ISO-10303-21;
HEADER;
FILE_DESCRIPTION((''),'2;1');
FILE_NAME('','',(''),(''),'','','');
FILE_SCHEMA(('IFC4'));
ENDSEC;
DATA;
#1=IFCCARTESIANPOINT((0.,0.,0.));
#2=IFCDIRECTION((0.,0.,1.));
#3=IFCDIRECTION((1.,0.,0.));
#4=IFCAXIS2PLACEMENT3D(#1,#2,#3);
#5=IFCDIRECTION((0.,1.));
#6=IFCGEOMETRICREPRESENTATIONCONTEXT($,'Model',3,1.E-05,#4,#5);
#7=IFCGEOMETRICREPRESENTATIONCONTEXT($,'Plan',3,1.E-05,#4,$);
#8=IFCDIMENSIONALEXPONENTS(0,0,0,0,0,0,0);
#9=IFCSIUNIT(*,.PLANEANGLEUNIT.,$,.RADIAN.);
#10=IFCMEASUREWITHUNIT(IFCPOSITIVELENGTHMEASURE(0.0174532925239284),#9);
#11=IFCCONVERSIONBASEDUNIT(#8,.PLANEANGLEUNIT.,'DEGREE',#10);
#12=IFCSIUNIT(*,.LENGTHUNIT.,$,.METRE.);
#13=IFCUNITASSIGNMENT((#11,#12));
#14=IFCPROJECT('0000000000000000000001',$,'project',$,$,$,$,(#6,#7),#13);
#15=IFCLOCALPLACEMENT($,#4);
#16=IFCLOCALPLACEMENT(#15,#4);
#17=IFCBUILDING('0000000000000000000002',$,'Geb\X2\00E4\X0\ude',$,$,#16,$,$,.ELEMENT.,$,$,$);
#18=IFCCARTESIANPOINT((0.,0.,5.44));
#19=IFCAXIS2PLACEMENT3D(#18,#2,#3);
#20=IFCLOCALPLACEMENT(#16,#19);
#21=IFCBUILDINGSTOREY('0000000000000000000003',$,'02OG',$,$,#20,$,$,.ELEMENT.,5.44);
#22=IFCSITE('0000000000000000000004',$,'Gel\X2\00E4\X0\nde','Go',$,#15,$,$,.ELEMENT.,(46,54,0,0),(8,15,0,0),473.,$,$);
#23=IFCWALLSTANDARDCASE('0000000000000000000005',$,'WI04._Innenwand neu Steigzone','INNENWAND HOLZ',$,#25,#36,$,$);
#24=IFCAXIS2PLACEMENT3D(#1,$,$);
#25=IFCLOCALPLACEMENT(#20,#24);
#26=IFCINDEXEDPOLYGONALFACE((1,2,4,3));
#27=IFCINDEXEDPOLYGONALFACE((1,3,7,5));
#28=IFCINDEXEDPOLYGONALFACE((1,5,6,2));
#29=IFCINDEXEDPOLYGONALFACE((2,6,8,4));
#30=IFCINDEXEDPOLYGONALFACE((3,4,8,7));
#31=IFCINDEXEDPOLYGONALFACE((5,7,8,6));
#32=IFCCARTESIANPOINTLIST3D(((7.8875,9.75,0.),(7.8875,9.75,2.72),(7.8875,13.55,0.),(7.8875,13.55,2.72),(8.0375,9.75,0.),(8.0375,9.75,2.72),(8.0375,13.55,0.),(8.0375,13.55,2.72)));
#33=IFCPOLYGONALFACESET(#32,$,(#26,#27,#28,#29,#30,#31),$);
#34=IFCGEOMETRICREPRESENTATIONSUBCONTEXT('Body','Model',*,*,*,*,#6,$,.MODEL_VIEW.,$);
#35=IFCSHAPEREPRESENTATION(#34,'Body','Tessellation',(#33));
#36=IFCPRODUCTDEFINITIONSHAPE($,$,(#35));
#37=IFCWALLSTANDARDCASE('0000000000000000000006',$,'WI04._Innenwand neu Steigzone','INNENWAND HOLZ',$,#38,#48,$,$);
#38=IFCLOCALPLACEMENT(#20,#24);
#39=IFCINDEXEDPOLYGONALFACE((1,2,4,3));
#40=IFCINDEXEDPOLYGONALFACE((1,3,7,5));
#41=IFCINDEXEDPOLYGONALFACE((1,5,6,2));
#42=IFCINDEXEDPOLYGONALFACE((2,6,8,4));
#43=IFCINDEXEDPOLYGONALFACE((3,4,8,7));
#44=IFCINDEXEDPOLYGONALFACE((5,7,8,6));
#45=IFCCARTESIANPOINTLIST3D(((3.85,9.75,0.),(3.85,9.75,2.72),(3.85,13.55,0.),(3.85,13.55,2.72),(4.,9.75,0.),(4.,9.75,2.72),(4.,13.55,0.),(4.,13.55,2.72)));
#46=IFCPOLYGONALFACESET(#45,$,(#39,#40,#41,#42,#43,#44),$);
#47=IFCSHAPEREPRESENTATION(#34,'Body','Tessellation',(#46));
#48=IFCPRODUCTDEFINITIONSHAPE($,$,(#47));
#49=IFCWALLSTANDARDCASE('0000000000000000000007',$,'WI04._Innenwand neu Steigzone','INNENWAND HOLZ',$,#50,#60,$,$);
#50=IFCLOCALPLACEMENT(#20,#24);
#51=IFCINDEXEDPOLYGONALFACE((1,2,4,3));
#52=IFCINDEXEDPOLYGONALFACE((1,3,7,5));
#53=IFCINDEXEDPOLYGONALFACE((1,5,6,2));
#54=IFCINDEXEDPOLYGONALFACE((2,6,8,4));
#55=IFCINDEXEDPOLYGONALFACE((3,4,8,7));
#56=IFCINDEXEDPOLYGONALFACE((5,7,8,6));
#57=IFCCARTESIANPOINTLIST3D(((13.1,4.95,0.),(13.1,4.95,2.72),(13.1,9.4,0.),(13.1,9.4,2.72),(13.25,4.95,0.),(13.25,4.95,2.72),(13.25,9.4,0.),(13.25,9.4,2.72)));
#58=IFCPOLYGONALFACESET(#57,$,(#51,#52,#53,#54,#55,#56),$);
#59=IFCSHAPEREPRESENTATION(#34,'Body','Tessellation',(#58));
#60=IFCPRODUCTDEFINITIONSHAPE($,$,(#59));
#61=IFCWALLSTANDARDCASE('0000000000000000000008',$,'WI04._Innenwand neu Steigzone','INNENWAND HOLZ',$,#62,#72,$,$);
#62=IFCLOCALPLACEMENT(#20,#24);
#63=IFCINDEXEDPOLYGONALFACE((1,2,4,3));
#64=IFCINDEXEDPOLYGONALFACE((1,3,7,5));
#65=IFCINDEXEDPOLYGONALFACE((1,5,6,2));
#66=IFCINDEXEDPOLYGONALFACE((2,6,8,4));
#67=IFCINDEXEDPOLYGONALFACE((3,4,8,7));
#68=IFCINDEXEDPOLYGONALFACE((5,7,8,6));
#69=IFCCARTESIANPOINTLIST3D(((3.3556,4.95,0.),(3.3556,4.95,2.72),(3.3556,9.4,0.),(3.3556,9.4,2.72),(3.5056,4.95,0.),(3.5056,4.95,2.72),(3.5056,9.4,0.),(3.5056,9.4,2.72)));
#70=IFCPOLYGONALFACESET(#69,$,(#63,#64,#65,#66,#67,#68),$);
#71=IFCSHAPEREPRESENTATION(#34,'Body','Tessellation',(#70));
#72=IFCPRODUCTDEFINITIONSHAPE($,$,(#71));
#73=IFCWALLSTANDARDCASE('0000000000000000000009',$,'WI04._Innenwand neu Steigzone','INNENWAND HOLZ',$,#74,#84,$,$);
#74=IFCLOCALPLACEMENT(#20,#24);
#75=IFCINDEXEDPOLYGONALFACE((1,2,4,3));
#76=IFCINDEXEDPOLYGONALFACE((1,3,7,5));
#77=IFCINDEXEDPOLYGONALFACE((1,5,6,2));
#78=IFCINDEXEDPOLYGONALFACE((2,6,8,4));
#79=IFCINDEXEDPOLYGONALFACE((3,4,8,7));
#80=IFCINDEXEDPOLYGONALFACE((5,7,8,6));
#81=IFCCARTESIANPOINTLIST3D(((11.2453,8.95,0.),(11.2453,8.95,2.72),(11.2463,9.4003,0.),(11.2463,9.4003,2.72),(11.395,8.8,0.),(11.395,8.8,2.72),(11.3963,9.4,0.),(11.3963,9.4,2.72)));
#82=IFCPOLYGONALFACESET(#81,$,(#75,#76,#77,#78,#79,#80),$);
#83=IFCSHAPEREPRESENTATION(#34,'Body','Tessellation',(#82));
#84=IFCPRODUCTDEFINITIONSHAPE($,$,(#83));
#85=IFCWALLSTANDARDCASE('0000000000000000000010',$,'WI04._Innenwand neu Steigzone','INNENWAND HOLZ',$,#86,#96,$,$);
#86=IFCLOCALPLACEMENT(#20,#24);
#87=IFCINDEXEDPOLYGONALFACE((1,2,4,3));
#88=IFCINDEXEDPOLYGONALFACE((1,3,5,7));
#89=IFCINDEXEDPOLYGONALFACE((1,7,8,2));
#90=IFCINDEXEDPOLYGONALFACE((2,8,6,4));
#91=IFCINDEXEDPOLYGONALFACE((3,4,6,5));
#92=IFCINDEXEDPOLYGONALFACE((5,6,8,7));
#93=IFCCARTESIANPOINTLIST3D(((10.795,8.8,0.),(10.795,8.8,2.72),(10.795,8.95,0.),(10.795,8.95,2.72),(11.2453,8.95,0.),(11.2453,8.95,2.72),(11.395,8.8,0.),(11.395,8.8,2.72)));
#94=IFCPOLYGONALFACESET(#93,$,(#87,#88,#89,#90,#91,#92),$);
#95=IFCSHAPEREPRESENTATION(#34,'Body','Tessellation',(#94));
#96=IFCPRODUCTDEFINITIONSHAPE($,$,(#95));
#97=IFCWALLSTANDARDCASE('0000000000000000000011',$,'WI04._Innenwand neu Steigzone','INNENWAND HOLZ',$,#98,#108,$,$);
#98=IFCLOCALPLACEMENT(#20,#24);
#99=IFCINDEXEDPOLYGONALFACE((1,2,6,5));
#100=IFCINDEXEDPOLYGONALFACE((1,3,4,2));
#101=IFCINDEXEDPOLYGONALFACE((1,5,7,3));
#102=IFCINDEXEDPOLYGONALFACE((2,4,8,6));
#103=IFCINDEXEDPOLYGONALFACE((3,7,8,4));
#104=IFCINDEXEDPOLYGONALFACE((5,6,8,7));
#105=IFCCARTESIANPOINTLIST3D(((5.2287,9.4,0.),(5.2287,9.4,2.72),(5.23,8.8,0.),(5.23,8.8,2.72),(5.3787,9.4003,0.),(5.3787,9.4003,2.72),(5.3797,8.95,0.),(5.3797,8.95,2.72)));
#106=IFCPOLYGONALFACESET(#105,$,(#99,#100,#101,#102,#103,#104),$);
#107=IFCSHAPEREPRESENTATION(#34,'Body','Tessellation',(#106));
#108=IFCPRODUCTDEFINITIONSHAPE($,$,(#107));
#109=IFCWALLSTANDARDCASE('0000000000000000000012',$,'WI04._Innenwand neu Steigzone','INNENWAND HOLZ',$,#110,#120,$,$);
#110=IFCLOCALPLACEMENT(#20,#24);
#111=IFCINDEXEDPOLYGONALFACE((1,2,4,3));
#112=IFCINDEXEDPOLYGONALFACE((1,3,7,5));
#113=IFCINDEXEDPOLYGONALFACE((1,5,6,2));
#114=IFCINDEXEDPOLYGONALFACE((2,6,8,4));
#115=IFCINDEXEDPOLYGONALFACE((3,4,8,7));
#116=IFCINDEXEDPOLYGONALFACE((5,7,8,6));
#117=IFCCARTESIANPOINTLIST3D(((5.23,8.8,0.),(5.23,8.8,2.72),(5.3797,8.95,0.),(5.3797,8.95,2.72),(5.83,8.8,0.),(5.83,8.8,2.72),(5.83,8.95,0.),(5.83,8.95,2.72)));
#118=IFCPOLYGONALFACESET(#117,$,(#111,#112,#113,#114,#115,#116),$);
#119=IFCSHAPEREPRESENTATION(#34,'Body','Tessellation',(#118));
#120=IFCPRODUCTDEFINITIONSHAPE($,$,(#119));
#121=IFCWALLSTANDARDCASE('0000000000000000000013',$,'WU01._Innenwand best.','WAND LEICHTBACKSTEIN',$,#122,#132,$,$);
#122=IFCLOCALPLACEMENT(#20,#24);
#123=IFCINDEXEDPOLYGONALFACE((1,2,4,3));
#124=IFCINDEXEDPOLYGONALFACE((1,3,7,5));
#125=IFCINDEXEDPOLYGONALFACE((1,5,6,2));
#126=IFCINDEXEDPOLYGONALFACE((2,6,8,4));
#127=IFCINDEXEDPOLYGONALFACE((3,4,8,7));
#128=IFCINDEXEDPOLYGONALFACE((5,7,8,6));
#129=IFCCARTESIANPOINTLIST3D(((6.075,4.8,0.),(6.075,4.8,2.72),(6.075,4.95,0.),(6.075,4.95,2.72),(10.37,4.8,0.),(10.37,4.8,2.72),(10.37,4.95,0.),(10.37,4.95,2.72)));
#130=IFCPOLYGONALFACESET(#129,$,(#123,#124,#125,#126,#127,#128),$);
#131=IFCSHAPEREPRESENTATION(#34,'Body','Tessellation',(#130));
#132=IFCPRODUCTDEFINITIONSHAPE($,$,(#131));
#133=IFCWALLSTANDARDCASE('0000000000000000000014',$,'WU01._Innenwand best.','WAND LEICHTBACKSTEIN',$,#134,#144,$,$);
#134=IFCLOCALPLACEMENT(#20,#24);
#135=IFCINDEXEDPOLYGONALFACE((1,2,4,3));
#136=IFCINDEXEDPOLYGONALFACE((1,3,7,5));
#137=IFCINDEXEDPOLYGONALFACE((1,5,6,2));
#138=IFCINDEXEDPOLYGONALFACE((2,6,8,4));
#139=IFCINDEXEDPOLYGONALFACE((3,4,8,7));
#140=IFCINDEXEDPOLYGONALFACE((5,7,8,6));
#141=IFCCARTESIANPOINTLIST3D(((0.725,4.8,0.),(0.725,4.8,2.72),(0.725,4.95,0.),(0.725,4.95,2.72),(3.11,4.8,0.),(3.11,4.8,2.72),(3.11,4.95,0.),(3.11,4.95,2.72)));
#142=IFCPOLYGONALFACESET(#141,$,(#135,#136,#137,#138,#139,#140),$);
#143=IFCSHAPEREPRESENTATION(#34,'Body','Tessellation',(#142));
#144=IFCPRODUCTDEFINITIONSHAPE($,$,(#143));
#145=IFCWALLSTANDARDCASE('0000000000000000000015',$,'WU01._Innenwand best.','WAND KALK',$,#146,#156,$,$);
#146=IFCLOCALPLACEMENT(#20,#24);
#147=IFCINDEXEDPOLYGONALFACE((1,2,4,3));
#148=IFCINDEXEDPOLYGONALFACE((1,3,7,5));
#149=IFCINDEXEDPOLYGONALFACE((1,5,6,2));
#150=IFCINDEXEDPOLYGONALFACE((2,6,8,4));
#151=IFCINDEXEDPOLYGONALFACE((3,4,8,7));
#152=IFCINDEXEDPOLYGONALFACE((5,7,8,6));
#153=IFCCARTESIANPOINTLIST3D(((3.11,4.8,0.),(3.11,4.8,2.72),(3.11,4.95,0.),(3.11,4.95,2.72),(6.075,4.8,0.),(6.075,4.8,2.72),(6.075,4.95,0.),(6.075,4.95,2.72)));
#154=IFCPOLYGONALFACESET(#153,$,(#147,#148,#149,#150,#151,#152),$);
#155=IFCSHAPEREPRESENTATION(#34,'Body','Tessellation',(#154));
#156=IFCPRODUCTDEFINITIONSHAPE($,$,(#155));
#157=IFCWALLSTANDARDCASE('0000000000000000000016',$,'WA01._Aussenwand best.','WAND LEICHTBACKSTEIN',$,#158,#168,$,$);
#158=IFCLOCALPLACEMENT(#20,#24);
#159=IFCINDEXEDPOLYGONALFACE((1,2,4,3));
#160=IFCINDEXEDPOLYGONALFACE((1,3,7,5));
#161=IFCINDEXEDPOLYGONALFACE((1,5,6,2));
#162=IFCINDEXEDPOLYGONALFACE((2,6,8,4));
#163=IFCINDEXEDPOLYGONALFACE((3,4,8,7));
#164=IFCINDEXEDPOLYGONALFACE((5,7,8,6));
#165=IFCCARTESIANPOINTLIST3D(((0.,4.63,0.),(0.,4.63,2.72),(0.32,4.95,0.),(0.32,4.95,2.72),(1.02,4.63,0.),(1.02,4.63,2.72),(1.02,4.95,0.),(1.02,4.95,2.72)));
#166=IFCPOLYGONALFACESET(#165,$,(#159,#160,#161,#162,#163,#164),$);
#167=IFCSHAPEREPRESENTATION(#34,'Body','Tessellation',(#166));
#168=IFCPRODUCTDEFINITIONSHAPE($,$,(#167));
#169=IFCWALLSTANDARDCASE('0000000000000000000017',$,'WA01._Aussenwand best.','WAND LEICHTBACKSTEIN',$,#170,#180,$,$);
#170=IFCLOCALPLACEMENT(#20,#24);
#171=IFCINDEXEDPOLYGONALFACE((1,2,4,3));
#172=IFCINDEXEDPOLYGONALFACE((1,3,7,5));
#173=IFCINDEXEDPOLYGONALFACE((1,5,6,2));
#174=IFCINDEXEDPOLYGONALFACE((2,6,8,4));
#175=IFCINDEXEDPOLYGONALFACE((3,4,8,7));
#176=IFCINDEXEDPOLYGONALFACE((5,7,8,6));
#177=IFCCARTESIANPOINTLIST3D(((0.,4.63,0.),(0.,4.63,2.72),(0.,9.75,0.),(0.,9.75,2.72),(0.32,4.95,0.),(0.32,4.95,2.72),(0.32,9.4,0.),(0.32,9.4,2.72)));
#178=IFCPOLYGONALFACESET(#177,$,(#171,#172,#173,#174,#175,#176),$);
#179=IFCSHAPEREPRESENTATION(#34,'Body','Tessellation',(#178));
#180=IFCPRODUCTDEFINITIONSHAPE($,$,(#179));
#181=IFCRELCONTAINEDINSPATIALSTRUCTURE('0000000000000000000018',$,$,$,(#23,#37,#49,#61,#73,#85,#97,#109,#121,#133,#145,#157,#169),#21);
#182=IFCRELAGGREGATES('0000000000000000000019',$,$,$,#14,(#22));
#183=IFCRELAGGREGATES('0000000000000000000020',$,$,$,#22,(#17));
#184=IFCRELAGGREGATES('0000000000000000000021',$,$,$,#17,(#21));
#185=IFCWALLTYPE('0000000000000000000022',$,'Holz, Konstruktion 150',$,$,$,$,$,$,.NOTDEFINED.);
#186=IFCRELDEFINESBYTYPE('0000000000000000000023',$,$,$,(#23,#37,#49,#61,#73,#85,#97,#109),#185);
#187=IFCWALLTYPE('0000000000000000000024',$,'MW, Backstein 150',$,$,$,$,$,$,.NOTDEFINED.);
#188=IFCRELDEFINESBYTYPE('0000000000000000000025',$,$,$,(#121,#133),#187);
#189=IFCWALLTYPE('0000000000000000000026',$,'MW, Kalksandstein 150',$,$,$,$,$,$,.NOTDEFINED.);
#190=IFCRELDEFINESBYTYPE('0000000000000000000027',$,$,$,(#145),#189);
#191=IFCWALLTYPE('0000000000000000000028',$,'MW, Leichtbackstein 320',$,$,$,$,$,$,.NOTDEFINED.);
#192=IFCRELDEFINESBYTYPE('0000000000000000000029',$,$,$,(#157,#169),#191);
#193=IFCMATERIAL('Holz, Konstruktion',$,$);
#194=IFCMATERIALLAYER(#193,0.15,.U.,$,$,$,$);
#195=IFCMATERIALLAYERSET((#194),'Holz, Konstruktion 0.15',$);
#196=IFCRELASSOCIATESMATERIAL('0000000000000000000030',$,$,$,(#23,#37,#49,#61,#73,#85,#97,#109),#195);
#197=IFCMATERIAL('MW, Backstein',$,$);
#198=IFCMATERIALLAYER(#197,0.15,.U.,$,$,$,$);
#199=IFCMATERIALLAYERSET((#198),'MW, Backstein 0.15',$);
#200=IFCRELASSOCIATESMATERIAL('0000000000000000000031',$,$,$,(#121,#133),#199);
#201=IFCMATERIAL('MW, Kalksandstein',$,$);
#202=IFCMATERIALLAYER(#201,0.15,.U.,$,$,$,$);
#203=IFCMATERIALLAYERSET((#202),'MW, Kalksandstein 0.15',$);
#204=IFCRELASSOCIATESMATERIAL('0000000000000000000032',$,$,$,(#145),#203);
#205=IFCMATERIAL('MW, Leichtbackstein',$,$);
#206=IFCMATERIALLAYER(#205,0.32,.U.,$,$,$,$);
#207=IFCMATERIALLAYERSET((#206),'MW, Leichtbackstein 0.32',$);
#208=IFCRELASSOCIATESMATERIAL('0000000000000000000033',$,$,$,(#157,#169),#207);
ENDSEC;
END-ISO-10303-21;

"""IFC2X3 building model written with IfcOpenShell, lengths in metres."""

from ifc_helpers import new_model, entity, si_unit, converted_unit, direction, frame, origin_with_axes, place, context, subcontext, project, spatial, polyline, outline, extrude, material, layer, layer_set, layer_usage, type_object, element, save


model = new_model("IFC2X3")

# Units and contexts
model_context = context("Model", 3, precision=1e-05, world=origin_with_axes(), true_north=direction((0.0, 1.0)))
plan_context = context("Plan", 3, precision=1e-05, world=origin_with_axes())
body_context = subcontext(model_context, "Body", "Model", "MODEL_VIEW")
ifc_project = project(units=[converted_unit("PLANEANGLEUNIT", "DEGREE", entity("IfcPositiveLengthMeasure", 0.0174532925239284), si_unit("PLANEANGLEUNIT", "RADIAN"), dimensions=[0, 0, 0, 0, 0, 0, 0]), si_unit("LENGTHUNIT", "METRE")], contexts=[model_context, plan_context])

# Site, building, storey
site_placement = place(None, origin_with_axes())
site = spatial("IfcSite", under=ifc_project, at=site_placement, Name="Gelände", Description="Go", CompositionType="ELEMENT", RefLatitude=(46, 54, 0, 0), RefLongitude=(8, 15, 0, 0), RefElevation=473.0)
building_placement = place(site_placement, origin_with_axes())
building = spatial("IfcBuilding", under=site, at=building_placement, Name="Gebäude", CompositionType="ELEMENT")
storey_placement = place(building_placement, frame((0.0, 0.0, 5.44), z_axis=(0.0, 0.0, 1.0), x_axis=(1.0, 0.0, 0.0)))
storey = spatial("IfcBuildingStorey", under=building, at=storey_placement, Name="02OG", CompositionType="ELEMENT", Elevation=5.44)

# Shared definitions
ifc_material_1 = material(Name="Holz, Konstruktion")

# Walls
ifc_layer_1 = layer(ifc_material_1, 0.15, ventilated="UNKNOWN")
ifc_layer_set_1 = layer_set([ifc_layer_1], Name="Holz, Konstruktion 0.15")
wall_type_1 = type_object("IfcWallType", Name="Holz, Konstruktion 150", PredefinedType="NOTDEFINED")
ifc_layer_usage_1 = layer_usage(ifc_layer_set_1, "AXIS2", "POSITIVE", 0.0)
wall_1_placement = place(storey_placement, frame((7.8875, 13.55, 0.0), z_axis=(0.0, 0.0, 1.0), x_axis=(0.0, -1.0, 0.0)))
element("IfcWallStandardCase", 1, at=wall_1_placement, inside=storey, type_object=wall_type_1, material=ifc_layer_usage_1, Name="WI04._Innenwand neu Steigzone", Description="INNENWAND HOLZ", context=body_context, shape_type="SweptSolid", body=[
    extrude(outline(polyline([(0.0, 0.0), (3.8, 0.0), (3.8, 0.15), (0.0, 0.15), (0.0, 0.0)])), origin_with_axes(), (0.0, 0.0, 1.0), 2.72),
])
ifc_layer_usage_2 = layer_usage(ifc_layer_set_1, "AXIS2", "NEGATIVE", 0.0)
wall_2_placement = place(storey_placement, frame((4.0, 13.55, 0.0), z_axis=(0.0, 0.0, 1.0), x_axis=(0.0, -1.0, 0.0)))
element("IfcWallStandardCase", 2, at=wall_2_placement, inside=storey, type_object=wall_type_1, material=ifc_layer_usage_2, Name="WI04._Innenwand neu Steigzone", Description="INNENWAND HOLZ", context=body_context, shape_type="SweptSolid", body=[
    extrude(outline(polyline([(0.0, -0.15), (3.8, -0.15), (3.8, 0.0), (0.0, 0.0), (0.0, -0.15)])), origin_with_axes(), (0.0, 0.0, 1.0), 2.72),
])
ifc_layer_usage_3 = layer_usage(ifc_layer_set_1, "AXIS2", "POSITIVE", 0.0)
wall_3_placement = place(storey_placement, frame((13.1, 9.4, 0.0), z_axis=(0.0, 0.0, 1.0), x_axis=(0.0, -1.0, 0.0)))
element("IfcWallStandardCase", 3, at=wall_3_placement, inside=storey, type_object=wall_type_1, material=ifc_layer_usage_3, Name="WI04._Innenwand neu Steigzone", Description="INNENWAND HOLZ", context=body_context, shape_type="SweptSolid", body=[
    extrude(outline(polyline([(0.0, 0.0), (4.45, 0.0), (4.45, 0.15), (0.0, 0.15), (0.0, 0.0)])), origin_with_axes(), (0.0, 0.0, 1.0), 2.72),
])
ifc_layer_usage_4 = layer_usage(ifc_layer_set_1, "AXIS2", "NEGATIVE", 0.0)
wall_4_placement = place(storey_placement, frame((3.5056, 9.4, 0.0), z_axis=(0.0, 0.0, 1.0), x_axis=(0.0, -1.0, 0.0)))
element("IfcWallStandardCase", 4, at=wall_4_placement, inside=storey, type_object=wall_type_1, material=ifc_layer_usage_4, Name="WI04._Innenwand neu Steigzone", Description="INNENWAND HOLZ", context=body_context, shape_type="SweptSolid", body=[
    extrude(outline(polyline([(0.0, -0.15), (4.45, -0.15), (4.45, 0.0), (0.0, 0.0), (0.0, -0.15)])), origin_with_axes(), (0.0, 0.0, 1.0), 2.72),
])
ifc_layer_usage_5 = layer_usage(ifc_layer_set_1, "AXIS2", "NEGATIVE", 0.0)
wall_5_placement = place(storey_placement, frame((11.3963, 9.4, 0.0), z_axis=(0.0, 0.0, 1.0), x_axis=(-0.002118, -0.999998, 0.0)))
element("IfcWallStandardCase", 5, at=wall_5_placement, inside=storey, type_object=wall_type_1, material=ifc_layer_usage_5, Name="WI04._Innenwand neu Steigzone", Description="INNENWAND HOLZ", context=body_context, shape_type="SweptSolid", body=[
    extrude(outline(polyline([(0.0, -0.15), (0.4503, -0.15), (0.6, 0.0), (0.0, 0.0), (0.0, -0.15)])), origin_with_axes(), (0.0, 0.0, 1.0), 2.72),
])
ifc_layer_usage_6 = layer_usage(ifc_layer_set_1, "AXIS2", "NEGATIVE", 0.0)
wall_6_placement = place(storey_placement, frame((11.395, 8.8, 0.0), z_axis=(0.0, 0.0, 1.0), x_axis=(-1.0, 0.0, 0.0)))
element("IfcWallStandardCase", 6, at=wall_6_placement, inside=storey, type_object=wall_type_1, material=ifc_layer_usage_6, Name="WI04._Innenwand neu Steigzone", Description="INNENWAND HOLZ", context=body_context, shape_type="SweptSolid", body=[
    extrude(outline(polyline([(0.1497, -0.15), (0.6, -0.15), (0.6, 0.0), (0.0, 0.0), (0.1497, -0.15)])), origin_with_axes(), (0.0, 0.0, 1.0), 2.72),
])
ifc_layer_usage_7 = layer_usage(ifc_layer_set_1, "AXIS2", "POSITIVE", 0.0)
wall_7_placement = place(storey_placement, frame((5.2287, 9.4, 0.0), z_axis=(0.0, 0.0, 1.0), x_axis=(0.002118, -0.999998, 0.0)))
element("IfcWallStandardCase", 7, at=wall_7_placement, inside=storey, type_object=wall_type_1, material=ifc_layer_usage_7, Name="WI04._Innenwand neu Steigzone", Description="INNENWAND HOLZ", context=body_context, shape_type="SweptSolid", body=[
    extrude(outline(polyline([(0.0, 0.0), (0.6, 0.0), (0.4503, 0.15), (0.0, 0.15), (0.0, 0.0)])), origin_with_axes(), (0.0, 0.0, 1.0), 2.72),
])
ifc_layer_usage_8 = layer_usage(ifc_layer_set_1, "AXIS2", "POSITIVE", 0.0)
wall_8_placement = place(storey_placement, frame((5.23, 8.8, 0.0), z_axis=(0.0, 0.0, 1.0), x_axis=(1.0, 0.0, 0.0)))
element("IfcWallStandardCase", 8, at=wall_8_placement, inside=storey, type_object=wall_type_1, material=ifc_layer_usage_8, Name="WI04._Innenwand neu Steigzone", Description="INNENWAND HOLZ", context=body_context, shape_type="SweptSolid", body=[
    extrude(outline(polyline([(0.0, 0.0), (0.6, 0.0), (0.6, 0.15), (0.1497, 0.15), (0.0, 0.0)])), origin_with_axes(), (0.0, 0.0, 1.0), 2.72),
])
ifc_material_2 = material(Name="MW, Backstein")
ifc_layer_2 = layer(ifc_material_2, 0.15, ventilated="UNKNOWN")
ifc_layer_set_2 = layer_set([ifc_layer_2], Name="MW, Backstein 0.15")
ifc_layer_usage_9 = layer_usage(ifc_layer_set_2, "AXIS2", "POSITIVE", -0.15)
wall_type_2 = type_object("IfcWallType", Name="MW, Backstein 150", PredefinedType="NOTDEFINED")
wall_9_placement = place(storey_placement, frame((6.075, 4.95, 0.0), z_axis=(0.0, 0.0, 1.0), x_axis=(1.0, 0.0, 0.0)))
element("IfcWallStandardCase", 9, at=wall_9_placement, inside=storey, type_object=wall_type_2, material=ifc_layer_usage_9, Name="WU01._Innenwand best.", Description="WAND LEICHTBACKSTEIN", context=body_context, shape_type="SweptSolid", body=[
    extrude(outline(polyline([(0.0, -0.15), (4.295, -0.15), (4.295, 0.0), (0.0, 0.0), (0.0, -0.15)])), origin_with_axes(), (0.0, 0.0, 1.0), 2.72),
])
ifc_layer_usage_10 = layer_usage(ifc_layer_set_2, "AXIS2", "POSITIVE", -0.15)
wall_10_placement = place(storey_placement, frame((0.725, 4.95, 0.0), z_axis=(0.0, 0.0, 1.0), x_axis=(1.0, 0.0, 0.0)))
element("IfcWallStandardCase", 10, at=wall_10_placement, inside=storey, type_object=wall_type_2, material=ifc_layer_usage_10, Name="WU01._Innenwand best.", Description="WAND LEICHTBACKSTEIN", context=body_context, shape_type="SweptSolid", body=[
    extrude(outline(polyline([(0.0, -0.15), (2.385, -0.15), (2.385, 0.0), (0.0, 0.0), (0.0, -0.15)])), origin_with_axes(), (0.0, 0.0, 1.0), 2.72),
])
ifc_material_3 = material(Name="MW, Kalksandstein")
ifc_layer_3 = layer(ifc_material_3, 0.15, ventilated="UNKNOWN")
ifc_layer_set_3 = layer_set([ifc_layer_3], Name="MW, Kalksandstein 0.15")
ifc_layer_usage_11 = layer_usage(ifc_layer_set_3, "AXIS2", "POSITIVE", -0.15)
wall_type_3 = type_object("IfcWallType", Name="MW, Kalksandstein 150", PredefinedType="NOTDEFINED")
wall_11_placement = place(storey_placement, frame((3.11, 4.95, 0.0), z_axis=(0.0, 0.0, 1.0), x_axis=(1.0, 0.0, 0.0)))
element("IfcWallStandardCase", 11, at=wall_11_placement, inside=storey, type_object=wall_type_3, material=ifc_layer_usage_11, Name="WU01._Innenwand best.", Description="WAND KALK", context=body_context, shape_type="SweptSolid", body=[
    extrude(outline(polyline([(0.0, -0.15), (2.965, -0.15), (2.965, 0.0), (0.0, 0.0), (0.0, -0.15)])), origin_with_axes(), (0.0, 0.0, 1.0), 2.72),
])
ifc_material_4 = material(Name="MW, Leichtbackstein")
ifc_layer_4 = layer(ifc_material_4, 0.32, ventilated="UNKNOWN")
ifc_layer_set_4 = layer_set([ifc_layer_4], Name="MW, Leichtbackstein 0.32")
wall_type_4 = type_object("IfcWallType", Name="MW, Leichtbackstein 320", PredefinedType="NOTDEFINED")
ifc_layer_usage_12 = layer_usage(ifc_layer_set_4, "AXIS2", "POSITIVE", -0.32)
wall_12_placement = place(storey_placement, frame((0.32, 4.95, 0.0), z_axis=(0.0, 0.0, 1.0), x_axis=(1.0, 0.0, 0.0)))
element("IfcWallStandardCase", 12, at=wall_12_placement, inside=storey, type_object=wall_type_4, material=ifc_layer_usage_12, Name="WA01._Aussenwand best.", Description="WAND LEICHTBACKSTEIN", context=body_context, shape_type="SweptSolid", body=[
    extrude(outline(polyline([(-0.32, -0.32), (0.7, -0.32), (0.7, 0.0), (0.0, 0.0), (-0.32, -0.32)])), origin_with_axes(), (0.0, 0.0, 1.0), 2.72),
])
ifc_layer_usage_13 = layer_usage(ifc_layer_set_4, "AXIS2", "POSITIVE", -0.32)
wall_13_placement = place(storey_placement, frame((0.32, 9.4, 0.0), z_axis=(0.0, 0.0, 1.0), x_axis=(0.0, -1.0, 0.0)))
element("IfcWallStandardCase", 13, at=wall_13_placement, inside=storey, type_object=wall_type_4, material=ifc_layer_usage_13, Name="WA01._Aussenwand best.", Description="WAND LEICHTBACKSTEIN", context=body_context, shape_type="SweptSolid", body=[
    extrude(outline(polyline([(-0.35, -0.32), (4.77, -0.32), (4.45, 0.0), (0.0, 0.0), (-0.35, -0.32)])), origin_with_axes(), (0.0, 0.0, 1.0), 2.72),
])

save(model, "model.ifc")
